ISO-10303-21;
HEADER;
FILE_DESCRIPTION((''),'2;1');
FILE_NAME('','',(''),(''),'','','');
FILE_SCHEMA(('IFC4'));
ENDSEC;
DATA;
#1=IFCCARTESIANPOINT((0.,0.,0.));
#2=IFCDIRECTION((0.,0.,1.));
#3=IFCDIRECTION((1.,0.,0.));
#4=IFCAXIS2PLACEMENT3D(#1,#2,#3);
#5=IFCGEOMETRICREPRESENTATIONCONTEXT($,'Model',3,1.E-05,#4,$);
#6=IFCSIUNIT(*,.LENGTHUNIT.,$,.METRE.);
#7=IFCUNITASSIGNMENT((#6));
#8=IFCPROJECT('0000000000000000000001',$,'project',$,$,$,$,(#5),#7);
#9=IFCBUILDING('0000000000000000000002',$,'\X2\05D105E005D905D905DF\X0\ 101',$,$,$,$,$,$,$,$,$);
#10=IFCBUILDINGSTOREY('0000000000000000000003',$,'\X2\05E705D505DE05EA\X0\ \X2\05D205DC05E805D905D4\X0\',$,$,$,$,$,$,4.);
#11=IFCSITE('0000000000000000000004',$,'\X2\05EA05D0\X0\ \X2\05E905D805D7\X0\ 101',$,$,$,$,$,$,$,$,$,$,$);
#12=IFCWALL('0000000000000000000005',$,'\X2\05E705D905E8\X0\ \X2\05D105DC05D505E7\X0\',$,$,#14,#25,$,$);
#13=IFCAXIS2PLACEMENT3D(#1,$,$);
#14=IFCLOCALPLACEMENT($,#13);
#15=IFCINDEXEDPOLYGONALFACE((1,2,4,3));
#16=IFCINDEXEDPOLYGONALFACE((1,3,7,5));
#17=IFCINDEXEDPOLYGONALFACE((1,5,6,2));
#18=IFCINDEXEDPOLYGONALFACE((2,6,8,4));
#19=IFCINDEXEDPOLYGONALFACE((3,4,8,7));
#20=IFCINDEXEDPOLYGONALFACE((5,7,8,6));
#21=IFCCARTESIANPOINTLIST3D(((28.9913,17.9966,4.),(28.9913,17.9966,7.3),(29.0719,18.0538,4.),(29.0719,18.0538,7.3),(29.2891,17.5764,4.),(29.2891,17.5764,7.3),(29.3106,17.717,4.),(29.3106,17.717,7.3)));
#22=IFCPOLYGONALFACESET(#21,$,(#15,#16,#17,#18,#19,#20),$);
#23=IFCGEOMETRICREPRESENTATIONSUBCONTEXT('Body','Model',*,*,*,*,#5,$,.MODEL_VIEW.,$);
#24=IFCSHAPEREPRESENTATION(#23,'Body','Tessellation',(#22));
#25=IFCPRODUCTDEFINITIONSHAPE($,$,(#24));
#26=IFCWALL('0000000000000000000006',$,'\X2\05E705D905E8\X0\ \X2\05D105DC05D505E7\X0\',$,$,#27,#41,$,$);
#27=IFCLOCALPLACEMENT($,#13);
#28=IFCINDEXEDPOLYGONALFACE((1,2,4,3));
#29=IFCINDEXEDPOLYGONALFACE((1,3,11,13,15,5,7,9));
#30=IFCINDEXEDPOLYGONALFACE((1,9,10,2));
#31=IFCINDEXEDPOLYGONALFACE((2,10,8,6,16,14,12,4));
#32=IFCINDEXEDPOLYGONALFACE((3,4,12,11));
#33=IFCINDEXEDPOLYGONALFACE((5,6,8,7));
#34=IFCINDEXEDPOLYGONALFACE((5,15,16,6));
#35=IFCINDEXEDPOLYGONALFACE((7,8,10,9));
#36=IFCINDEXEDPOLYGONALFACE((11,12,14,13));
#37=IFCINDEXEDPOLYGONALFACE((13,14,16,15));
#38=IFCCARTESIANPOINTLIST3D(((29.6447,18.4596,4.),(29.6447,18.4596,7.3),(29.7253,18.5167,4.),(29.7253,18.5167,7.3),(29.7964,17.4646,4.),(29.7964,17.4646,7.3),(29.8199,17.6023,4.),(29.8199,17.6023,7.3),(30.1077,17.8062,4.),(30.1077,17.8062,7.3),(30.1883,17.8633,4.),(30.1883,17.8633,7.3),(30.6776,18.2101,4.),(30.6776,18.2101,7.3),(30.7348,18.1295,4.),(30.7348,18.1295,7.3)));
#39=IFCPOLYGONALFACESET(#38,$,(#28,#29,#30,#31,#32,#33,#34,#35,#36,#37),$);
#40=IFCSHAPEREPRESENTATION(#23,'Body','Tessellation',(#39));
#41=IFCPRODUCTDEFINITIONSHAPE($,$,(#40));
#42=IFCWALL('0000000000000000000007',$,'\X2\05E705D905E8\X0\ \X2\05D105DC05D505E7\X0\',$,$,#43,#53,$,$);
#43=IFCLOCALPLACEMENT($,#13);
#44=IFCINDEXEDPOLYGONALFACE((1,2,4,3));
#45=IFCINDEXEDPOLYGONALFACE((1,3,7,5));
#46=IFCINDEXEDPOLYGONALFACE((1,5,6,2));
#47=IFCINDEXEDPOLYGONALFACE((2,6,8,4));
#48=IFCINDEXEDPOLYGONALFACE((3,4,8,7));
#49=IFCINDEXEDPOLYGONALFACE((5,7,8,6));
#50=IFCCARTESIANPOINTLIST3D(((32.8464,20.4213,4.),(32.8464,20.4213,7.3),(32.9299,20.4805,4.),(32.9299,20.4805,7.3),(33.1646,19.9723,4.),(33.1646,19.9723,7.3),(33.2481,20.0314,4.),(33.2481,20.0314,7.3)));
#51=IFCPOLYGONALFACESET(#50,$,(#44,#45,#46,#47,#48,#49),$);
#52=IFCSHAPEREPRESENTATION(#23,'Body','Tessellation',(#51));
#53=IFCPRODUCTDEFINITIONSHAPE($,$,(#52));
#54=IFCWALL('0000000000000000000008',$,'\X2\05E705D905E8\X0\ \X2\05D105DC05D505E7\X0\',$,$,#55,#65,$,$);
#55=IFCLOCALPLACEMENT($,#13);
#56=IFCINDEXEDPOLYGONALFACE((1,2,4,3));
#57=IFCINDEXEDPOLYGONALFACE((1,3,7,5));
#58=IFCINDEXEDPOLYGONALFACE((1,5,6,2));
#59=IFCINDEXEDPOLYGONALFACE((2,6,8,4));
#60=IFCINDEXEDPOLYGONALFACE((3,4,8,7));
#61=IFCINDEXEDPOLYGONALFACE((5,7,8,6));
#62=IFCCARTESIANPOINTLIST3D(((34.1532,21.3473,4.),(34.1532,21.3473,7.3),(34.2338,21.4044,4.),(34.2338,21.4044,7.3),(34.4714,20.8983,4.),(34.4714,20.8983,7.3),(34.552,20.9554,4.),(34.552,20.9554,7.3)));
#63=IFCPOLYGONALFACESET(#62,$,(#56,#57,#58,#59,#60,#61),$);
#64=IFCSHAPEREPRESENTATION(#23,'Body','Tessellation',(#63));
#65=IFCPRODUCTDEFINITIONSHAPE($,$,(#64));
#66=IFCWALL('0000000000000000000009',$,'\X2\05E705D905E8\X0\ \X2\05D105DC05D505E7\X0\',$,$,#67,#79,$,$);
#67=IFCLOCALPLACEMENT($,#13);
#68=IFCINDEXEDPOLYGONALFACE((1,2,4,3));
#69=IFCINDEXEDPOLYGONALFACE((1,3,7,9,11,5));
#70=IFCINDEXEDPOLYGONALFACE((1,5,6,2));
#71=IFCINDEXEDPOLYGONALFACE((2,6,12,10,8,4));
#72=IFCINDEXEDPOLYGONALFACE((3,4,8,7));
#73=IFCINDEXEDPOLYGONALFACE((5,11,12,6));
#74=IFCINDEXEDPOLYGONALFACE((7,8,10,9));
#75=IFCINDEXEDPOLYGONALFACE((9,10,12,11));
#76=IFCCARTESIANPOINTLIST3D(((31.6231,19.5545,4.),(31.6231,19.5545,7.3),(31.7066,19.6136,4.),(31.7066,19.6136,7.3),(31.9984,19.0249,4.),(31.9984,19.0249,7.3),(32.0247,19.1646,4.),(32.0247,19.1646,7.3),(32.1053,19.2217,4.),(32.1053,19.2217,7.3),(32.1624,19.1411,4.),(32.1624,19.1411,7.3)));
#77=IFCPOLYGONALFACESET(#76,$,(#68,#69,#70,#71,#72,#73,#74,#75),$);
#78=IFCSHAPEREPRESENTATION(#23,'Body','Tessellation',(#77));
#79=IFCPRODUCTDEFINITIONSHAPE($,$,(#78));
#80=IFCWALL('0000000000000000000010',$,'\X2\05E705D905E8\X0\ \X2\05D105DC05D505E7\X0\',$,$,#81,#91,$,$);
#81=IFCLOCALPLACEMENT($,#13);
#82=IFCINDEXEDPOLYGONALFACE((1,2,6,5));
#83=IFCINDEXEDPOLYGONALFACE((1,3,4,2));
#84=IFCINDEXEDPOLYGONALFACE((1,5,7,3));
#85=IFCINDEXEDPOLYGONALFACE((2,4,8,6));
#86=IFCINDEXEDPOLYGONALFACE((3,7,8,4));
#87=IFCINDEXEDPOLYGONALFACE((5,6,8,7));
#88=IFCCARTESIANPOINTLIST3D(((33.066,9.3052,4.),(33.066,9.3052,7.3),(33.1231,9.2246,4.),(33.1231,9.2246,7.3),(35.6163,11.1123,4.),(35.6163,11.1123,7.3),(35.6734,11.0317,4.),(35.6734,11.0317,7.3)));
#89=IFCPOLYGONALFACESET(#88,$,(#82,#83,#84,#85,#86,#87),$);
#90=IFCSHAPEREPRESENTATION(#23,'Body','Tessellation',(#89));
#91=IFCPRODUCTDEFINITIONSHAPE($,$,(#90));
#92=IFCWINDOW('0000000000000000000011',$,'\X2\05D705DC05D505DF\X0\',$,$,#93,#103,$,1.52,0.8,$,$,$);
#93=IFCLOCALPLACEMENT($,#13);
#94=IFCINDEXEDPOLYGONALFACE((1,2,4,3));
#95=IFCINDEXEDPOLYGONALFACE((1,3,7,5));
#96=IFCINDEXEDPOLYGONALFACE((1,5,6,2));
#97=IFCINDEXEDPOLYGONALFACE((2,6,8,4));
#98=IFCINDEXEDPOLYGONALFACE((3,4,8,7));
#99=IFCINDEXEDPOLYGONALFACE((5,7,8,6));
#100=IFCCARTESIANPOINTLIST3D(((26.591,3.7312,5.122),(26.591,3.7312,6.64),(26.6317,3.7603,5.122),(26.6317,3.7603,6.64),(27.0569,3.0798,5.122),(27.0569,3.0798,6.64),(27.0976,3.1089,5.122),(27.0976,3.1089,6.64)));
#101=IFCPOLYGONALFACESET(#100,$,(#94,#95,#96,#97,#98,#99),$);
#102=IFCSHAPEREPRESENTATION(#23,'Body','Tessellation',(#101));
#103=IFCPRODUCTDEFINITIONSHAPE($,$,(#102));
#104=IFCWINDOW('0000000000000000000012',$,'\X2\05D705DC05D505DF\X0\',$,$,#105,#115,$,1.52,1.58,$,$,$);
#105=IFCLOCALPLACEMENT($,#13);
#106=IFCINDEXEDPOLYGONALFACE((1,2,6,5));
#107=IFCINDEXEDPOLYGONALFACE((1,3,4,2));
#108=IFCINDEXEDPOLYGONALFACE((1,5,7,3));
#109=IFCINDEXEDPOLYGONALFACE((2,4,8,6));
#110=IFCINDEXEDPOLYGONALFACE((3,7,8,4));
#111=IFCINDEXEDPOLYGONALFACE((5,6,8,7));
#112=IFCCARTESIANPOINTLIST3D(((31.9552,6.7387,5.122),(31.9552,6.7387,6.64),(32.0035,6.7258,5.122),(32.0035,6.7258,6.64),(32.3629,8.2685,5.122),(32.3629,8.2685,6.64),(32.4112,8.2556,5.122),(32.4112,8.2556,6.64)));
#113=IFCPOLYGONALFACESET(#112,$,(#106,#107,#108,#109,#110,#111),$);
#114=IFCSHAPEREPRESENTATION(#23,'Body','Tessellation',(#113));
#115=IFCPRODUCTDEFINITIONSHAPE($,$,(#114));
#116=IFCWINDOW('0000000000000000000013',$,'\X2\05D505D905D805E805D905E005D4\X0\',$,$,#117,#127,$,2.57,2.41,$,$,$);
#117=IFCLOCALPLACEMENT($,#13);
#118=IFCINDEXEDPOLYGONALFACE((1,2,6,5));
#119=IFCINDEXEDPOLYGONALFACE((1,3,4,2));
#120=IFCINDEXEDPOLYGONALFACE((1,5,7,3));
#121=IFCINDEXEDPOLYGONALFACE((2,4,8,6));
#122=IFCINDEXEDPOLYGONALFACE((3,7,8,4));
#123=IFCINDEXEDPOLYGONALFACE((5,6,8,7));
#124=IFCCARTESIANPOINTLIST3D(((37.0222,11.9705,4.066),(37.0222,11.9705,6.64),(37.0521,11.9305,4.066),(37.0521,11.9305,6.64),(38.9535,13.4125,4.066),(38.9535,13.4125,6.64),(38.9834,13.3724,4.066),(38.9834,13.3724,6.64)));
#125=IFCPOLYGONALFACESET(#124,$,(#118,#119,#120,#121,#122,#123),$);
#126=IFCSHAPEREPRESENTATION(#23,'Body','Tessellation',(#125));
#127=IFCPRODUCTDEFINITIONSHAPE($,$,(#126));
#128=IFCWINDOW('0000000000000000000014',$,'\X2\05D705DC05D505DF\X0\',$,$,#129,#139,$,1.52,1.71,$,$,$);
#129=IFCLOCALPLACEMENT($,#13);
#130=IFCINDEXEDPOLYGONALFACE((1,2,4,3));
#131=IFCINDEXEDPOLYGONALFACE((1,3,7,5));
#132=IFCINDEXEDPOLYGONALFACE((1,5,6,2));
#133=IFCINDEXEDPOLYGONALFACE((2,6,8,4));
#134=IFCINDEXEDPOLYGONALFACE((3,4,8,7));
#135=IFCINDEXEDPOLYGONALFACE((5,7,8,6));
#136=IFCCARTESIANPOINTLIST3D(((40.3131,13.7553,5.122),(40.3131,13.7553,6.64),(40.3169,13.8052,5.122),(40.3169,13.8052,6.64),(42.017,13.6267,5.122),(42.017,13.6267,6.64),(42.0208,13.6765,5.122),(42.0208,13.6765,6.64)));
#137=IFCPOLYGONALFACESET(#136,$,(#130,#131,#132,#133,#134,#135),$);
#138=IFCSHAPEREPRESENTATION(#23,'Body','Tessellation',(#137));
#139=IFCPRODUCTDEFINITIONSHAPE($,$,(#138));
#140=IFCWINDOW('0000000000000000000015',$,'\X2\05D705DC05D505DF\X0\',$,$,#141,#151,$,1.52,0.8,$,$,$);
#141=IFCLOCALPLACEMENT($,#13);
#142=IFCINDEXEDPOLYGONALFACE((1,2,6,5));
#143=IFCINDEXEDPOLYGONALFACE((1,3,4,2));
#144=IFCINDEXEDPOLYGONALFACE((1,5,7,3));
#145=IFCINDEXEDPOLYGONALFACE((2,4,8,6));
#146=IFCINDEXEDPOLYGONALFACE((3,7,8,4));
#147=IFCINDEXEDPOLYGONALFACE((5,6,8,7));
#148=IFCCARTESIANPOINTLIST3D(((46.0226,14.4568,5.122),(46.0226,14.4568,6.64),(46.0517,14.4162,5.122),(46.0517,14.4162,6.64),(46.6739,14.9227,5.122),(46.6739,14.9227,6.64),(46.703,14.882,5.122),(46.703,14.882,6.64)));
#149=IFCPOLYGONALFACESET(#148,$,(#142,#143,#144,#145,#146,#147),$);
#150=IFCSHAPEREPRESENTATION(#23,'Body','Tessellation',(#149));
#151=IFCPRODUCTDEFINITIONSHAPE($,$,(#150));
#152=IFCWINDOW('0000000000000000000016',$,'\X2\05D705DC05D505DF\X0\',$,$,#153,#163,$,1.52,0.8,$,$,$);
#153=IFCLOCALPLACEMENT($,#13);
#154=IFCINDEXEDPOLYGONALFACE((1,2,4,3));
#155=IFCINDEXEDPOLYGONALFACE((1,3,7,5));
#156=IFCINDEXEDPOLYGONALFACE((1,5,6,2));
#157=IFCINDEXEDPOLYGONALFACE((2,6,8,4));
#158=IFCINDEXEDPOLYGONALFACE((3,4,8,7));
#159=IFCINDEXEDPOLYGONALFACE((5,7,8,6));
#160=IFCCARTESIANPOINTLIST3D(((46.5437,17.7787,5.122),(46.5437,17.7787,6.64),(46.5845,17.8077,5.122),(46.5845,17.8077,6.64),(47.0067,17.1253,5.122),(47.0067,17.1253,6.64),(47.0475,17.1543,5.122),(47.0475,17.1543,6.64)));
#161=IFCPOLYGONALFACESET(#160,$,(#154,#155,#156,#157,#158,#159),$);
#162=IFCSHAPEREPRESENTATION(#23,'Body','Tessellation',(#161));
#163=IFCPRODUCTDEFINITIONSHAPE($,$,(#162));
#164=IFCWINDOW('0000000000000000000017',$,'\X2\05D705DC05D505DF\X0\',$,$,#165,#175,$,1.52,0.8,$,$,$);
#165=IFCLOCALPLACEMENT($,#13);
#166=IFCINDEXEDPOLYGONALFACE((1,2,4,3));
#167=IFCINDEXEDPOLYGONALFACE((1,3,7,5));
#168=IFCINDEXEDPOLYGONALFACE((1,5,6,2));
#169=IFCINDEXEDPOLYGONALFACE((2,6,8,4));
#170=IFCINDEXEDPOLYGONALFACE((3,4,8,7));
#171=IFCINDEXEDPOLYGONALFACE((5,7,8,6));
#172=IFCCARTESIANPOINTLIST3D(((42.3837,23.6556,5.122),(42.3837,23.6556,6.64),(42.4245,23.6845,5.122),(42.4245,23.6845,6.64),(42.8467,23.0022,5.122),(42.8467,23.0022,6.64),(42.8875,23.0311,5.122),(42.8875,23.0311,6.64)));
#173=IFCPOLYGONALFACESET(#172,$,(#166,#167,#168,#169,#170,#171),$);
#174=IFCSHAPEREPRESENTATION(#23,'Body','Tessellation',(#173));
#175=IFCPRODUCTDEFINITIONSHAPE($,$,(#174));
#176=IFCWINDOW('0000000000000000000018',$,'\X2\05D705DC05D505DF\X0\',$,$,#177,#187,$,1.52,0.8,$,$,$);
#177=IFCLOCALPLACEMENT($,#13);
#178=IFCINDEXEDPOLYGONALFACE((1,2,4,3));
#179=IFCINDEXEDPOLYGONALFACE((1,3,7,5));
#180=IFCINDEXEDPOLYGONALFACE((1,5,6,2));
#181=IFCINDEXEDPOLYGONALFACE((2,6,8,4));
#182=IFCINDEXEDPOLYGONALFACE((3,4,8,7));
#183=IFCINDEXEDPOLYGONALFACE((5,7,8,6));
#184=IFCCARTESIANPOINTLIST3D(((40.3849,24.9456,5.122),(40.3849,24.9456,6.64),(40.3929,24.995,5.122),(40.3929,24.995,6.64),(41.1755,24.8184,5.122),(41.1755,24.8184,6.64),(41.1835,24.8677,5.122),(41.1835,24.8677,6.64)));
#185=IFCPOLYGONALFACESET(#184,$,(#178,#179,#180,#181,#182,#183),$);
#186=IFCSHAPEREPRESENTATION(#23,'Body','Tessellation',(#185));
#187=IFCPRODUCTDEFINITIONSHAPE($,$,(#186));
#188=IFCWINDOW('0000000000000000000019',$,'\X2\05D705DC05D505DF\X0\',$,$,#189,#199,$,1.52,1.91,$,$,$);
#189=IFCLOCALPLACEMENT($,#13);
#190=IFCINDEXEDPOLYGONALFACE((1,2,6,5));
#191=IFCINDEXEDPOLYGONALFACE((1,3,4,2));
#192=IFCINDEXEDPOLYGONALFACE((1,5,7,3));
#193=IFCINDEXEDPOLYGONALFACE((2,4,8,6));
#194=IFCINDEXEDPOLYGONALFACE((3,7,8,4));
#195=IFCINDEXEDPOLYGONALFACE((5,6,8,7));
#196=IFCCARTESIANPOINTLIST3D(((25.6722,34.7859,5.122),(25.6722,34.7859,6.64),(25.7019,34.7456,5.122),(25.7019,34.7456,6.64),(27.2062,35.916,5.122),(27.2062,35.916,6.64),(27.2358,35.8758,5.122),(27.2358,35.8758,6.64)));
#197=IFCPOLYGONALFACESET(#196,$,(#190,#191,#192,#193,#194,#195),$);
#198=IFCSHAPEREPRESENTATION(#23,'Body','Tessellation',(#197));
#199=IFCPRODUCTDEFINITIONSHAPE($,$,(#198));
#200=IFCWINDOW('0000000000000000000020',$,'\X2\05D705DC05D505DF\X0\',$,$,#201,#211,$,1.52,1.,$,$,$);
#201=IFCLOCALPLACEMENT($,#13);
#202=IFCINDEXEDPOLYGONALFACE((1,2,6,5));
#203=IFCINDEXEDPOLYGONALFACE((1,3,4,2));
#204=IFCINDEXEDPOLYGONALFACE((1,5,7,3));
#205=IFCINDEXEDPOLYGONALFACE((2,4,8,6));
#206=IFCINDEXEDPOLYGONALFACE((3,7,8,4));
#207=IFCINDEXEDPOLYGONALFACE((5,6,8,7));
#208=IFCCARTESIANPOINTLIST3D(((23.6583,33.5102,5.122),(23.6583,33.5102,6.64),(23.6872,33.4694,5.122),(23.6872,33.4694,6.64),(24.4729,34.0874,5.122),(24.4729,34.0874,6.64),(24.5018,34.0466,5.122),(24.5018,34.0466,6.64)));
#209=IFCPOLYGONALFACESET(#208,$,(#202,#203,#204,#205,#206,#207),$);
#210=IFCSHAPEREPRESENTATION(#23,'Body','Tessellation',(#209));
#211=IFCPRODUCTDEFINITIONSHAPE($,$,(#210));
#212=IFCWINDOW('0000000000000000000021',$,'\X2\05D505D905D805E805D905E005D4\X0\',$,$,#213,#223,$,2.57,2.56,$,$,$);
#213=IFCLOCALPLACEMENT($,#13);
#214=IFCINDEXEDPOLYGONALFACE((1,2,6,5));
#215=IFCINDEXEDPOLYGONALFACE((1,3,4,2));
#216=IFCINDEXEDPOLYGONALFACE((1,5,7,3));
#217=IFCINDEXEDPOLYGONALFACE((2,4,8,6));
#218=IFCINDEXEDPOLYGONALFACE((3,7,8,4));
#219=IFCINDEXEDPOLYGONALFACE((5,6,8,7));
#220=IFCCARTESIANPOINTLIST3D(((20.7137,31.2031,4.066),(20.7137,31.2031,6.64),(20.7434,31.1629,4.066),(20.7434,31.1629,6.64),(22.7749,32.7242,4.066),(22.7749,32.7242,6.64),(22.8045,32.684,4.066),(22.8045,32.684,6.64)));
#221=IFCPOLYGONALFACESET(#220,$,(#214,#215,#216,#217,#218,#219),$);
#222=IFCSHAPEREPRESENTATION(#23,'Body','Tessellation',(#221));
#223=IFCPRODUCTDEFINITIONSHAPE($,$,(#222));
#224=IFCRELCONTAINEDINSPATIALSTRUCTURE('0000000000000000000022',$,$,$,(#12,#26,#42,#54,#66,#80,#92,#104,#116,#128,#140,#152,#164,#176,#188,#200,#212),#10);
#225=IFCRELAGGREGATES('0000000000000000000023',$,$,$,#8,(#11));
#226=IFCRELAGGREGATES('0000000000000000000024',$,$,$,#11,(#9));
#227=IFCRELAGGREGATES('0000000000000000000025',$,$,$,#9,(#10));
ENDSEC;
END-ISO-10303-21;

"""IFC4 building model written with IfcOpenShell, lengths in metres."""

from ifc_helpers import new_model, si_unit, frame, origin_with_axes, context, subcontext, project, spatial, polyline, outline, extrude, element, save


model = new_model("IFC4")

# Units and contexts
model_context = context("Model", 3, precision=1e-05, world=origin_with_axes())
body_context = subcontext(model_context, "Body", "Model", "MODEL_VIEW")
ifc_project = project(units=[si_unit("LENGTHUNIT", "METRE")], contexts=[model_context])

# Site, building, storey
site = spatial("IfcSite", under=ifc_project, Name="תא שטח 101")
building = spatial("IfcBuilding", under=site, Name="בניין 101")
storey = spatial("IfcBuildingStorey", under=building, Name="קומת גלריה", Elevation=4.0)

# Walls
element("IfcWall", 1, inside=storey, Name="קיר בלוק", context=body_context, shape_type="SweptSolid", body=[
    extrude(outline(polyline([(29.2891, 17.5764), (29.3106, 17.717), (29.0719, 18.0538), (28.9913, 17.9966), (29.2891, 17.5764)])), frame((0.0, 0.0, 4.0)), (0.0, 0.0, 1.0), 3.3),
])
element("IfcWall", 2, inside=storey, Name="קיר בלוק", context=body_context, shape_type="SweptSolid", body=[
    extrude(outline(polyline([(30.1077, 17.8062), (29.8199, 17.6023), (29.7964, 17.4646), (30.7348, 18.1295), (30.6776, 18.2101), (30.1883, 17.8633), (29.7253, 18.5167), (29.6447, 18.4596), (30.1077, 17.8062)])), frame((0.0, 0.0, 4.0)), (0.0, 0.0, 1.0), 3.3),
])
element("IfcWall", 3, inside=storey, Name="קיר בלוק", context=body_context, shape_type="SweptSolid", body=[
    extrude(outline(polyline([(32.9299, 20.4805), (32.8464, 20.4213), (33.1646, 19.9723), (33.2481, 20.0314), (32.9299, 20.4805)])), frame((0.0, 0.0, 4.0)), (0.0, 0.0, 1.0), 3.3),
])
element("IfcWall", 4, inside=storey, Name="קיר בלוק", context=body_context, shape_type="SweptSolid", body=[
    extrude(outline(polyline([(34.4714, 20.8983), (34.552, 20.9554), (34.2338, 21.4044), (34.1532, 21.3473), (34.4714, 20.8983)])), frame((0.0, 0.0, 4.0)), (0.0, 0.0, 1.0), 3.3),
])
element("IfcWall", 5, inside=storey, Name="קיר בלוק", context=body_context, shape_type="SweptSolid", body=[
    extrude(outline(polyline([(31.9984, 19.0249), (32.1624, 19.1411), (32.1053, 19.2217), (32.0247, 19.1646), (31.7066, 19.6136), (31.6231, 19.5545), (31.9984, 19.0249)])), frame((0.0, 0.0, 4.0)), (0.0, 0.0, 1.0), 3.3),
])
element("IfcWall", 6, inside=storey, Name="קיר בלוק", context=body_context, shape_type="SweptSolid", body=[
    extrude(outline(polyline([(35.6163, 11.1123), (33.066, 9.3052), (33.1231, 9.2246), (35.6734, 11.0317), (35.6163, 11.1123)])), frame((0.0, 0.0, 4.0)), (0.0, 0.0, 1.0), 3.3),
])

# Windows
element("IfcWindow", 7, inside=storey, Name="חלון", OverallHeight=1.52, OverallWidth=0.8, context=body_context, shape_type="SweptSolid", body=[
    extrude(outline(polyline([(26.591, 3.7312), (27.0569, 3.0798), (27.0976, 3.1089), (26.6317, 3.7603), (26.591, 3.7312)])), frame((0.0, 0.0, 5.122)), (0.0, 0.0, 1.0), 1.518),
])
element("IfcWindow", 8, inside=storey, Name="חלון", OverallHeight=1.52, OverallWidth=1.58, context=body_context, shape_type="SweptSolid", body=[
    extrude(outline(polyline([(32.0035, 6.7258), (32.4112, 8.2556), (32.3629, 8.2685), (31.9552, 6.7387), (32.0035, 6.7258)])), frame((0.0, 0.0, 5.122)), (0.0, 0.0, 1.0), 1.518),
])
element("IfcWindow", 9, inside=storey, Name="ויטרינה", OverallHeight=2.57, OverallWidth=2.41, context=body_context, shape_type="SweptSolid", body=[
    extrude(outline(polyline([(37.0521, 11.9305), (38.9834, 13.3724), (38.9535, 13.4125), (37.0222, 11.9705), (37.0521, 11.9305)])), frame((0.0, 0.0, 4.066)), (0.0, 0.0, 1.0), 2.574),
])
element("IfcWindow", 10, inside=storey, Name="חלון", OverallHeight=1.52, OverallWidth=1.71, context=body_context, shape_type="SweptSolid", body=[
    extrude(outline(polyline([(40.3131, 13.7553), (42.017, 13.6267), (42.0208, 13.6765), (40.3169, 13.8052), (40.3131, 13.7553)])), frame((0.0, 0.0, 5.122)), (0.0, 0.0, 1.0), 1.518),
])
element("IfcWindow", 11, inside=storey, Name="חלון", OverallHeight=1.52, OverallWidth=0.8, context=body_context, shape_type="SweptSolid", body=[
    extrude(outline(polyline([(46.0517, 14.4162), (46.703, 14.882), (46.6739, 14.9227), (46.0226, 14.4568), (46.0517, 14.4162)])), frame((0.0, 0.0, 5.122)), (0.0, 0.0, 1.0), 1.518),
])
element("IfcWindow", 12, inside=storey, Name="חלון", OverallHeight=1.52, OverallWidth=0.8, context=body_context, shape_type="SweptSolid", body=[
    extrude(outline(polyline([(47.0475, 17.1543), (46.5845, 17.8077), (46.5437, 17.7787), (47.0067, 17.1253), (47.0475, 17.1543)])), frame((0.0, 0.0, 5.122)), (0.0, 0.0, 1.0), 1.518),
])
element("IfcWindow", 13, inside=storey, Name="חלון", OverallHeight=1.52, OverallWidth=0.8, context=body_context, shape_type="SweptSolid", body=[
    extrude(outline(polyline([(42.8875, 23.0311), (42.4245, 23.6845), (42.3837, 23.6556), (42.8467, 23.0022), (42.8875, 23.0311)])), frame((0.0, 0.0, 5.122)), (0.0, 0.0, 1.0), 1.518),
])
element("IfcWindow", 14, inside=storey, Name="חלון", OverallHeight=1.52, OverallWidth=0.8, context=body_context, shape_type="SweptSolid", body=[
    extrude(outline(polyline([(41.1835, 24.8677), (40.3929, 24.995), (40.3849, 24.9456), (41.1755, 24.8184), (41.1835, 24.8677)])), frame((0.0, 0.0, 5.122)), (0.0, 0.0, 1.0), 1.518),
])
element("IfcWindow", 15, inside=storey, Name="חלון", OverallHeight=1.52, OverallWidth=1.91, context=body_context, shape_type="SweptSolid", body=[
    extrude(outline(polyline([(27.2062, 35.916), (25.6722, 34.7859), (25.7019, 34.7456), (27.2358, 35.8758), (27.2062, 35.916)])), frame((0.0, 0.0, 5.122)), (0.0, 0.0, 1.0), 1.518),
])
element("IfcWindow", 16, inside=storey, Name="חלון", OverallHeight=1.52, OverallWidth=1.0, context=body_context, shape_type="SweptSolid", body=[
    extrude(outline(polyline([(24.4729, 34.0874), (23.6583, 33.5102), (23.6872, 33.4694), (24.5018, 34.0466), (24.4729, 34.0874)])), frame((0.0, 0.0, 5.122)), (0.0, 0.0, 1.0), 1.518),
])
element("IfcWindow", 17, inside=storey, Name="ויטרינה", OverallHeight=2.57, OverallWidth=2.56, context=body_context, shape_type="SweptSolid", body=[
    extrude(outline(polyline([(22.7749, 32.7242), (20.7137, 31.2031), (20.7434, 31.1629), (22.8045, 32.684), (22.7749, 32.7242)])), frame((0.0, 0.0, 4.066)), (0.0, 0.0, 1.0), 2.574),
])

save(model, "model.ifc")
